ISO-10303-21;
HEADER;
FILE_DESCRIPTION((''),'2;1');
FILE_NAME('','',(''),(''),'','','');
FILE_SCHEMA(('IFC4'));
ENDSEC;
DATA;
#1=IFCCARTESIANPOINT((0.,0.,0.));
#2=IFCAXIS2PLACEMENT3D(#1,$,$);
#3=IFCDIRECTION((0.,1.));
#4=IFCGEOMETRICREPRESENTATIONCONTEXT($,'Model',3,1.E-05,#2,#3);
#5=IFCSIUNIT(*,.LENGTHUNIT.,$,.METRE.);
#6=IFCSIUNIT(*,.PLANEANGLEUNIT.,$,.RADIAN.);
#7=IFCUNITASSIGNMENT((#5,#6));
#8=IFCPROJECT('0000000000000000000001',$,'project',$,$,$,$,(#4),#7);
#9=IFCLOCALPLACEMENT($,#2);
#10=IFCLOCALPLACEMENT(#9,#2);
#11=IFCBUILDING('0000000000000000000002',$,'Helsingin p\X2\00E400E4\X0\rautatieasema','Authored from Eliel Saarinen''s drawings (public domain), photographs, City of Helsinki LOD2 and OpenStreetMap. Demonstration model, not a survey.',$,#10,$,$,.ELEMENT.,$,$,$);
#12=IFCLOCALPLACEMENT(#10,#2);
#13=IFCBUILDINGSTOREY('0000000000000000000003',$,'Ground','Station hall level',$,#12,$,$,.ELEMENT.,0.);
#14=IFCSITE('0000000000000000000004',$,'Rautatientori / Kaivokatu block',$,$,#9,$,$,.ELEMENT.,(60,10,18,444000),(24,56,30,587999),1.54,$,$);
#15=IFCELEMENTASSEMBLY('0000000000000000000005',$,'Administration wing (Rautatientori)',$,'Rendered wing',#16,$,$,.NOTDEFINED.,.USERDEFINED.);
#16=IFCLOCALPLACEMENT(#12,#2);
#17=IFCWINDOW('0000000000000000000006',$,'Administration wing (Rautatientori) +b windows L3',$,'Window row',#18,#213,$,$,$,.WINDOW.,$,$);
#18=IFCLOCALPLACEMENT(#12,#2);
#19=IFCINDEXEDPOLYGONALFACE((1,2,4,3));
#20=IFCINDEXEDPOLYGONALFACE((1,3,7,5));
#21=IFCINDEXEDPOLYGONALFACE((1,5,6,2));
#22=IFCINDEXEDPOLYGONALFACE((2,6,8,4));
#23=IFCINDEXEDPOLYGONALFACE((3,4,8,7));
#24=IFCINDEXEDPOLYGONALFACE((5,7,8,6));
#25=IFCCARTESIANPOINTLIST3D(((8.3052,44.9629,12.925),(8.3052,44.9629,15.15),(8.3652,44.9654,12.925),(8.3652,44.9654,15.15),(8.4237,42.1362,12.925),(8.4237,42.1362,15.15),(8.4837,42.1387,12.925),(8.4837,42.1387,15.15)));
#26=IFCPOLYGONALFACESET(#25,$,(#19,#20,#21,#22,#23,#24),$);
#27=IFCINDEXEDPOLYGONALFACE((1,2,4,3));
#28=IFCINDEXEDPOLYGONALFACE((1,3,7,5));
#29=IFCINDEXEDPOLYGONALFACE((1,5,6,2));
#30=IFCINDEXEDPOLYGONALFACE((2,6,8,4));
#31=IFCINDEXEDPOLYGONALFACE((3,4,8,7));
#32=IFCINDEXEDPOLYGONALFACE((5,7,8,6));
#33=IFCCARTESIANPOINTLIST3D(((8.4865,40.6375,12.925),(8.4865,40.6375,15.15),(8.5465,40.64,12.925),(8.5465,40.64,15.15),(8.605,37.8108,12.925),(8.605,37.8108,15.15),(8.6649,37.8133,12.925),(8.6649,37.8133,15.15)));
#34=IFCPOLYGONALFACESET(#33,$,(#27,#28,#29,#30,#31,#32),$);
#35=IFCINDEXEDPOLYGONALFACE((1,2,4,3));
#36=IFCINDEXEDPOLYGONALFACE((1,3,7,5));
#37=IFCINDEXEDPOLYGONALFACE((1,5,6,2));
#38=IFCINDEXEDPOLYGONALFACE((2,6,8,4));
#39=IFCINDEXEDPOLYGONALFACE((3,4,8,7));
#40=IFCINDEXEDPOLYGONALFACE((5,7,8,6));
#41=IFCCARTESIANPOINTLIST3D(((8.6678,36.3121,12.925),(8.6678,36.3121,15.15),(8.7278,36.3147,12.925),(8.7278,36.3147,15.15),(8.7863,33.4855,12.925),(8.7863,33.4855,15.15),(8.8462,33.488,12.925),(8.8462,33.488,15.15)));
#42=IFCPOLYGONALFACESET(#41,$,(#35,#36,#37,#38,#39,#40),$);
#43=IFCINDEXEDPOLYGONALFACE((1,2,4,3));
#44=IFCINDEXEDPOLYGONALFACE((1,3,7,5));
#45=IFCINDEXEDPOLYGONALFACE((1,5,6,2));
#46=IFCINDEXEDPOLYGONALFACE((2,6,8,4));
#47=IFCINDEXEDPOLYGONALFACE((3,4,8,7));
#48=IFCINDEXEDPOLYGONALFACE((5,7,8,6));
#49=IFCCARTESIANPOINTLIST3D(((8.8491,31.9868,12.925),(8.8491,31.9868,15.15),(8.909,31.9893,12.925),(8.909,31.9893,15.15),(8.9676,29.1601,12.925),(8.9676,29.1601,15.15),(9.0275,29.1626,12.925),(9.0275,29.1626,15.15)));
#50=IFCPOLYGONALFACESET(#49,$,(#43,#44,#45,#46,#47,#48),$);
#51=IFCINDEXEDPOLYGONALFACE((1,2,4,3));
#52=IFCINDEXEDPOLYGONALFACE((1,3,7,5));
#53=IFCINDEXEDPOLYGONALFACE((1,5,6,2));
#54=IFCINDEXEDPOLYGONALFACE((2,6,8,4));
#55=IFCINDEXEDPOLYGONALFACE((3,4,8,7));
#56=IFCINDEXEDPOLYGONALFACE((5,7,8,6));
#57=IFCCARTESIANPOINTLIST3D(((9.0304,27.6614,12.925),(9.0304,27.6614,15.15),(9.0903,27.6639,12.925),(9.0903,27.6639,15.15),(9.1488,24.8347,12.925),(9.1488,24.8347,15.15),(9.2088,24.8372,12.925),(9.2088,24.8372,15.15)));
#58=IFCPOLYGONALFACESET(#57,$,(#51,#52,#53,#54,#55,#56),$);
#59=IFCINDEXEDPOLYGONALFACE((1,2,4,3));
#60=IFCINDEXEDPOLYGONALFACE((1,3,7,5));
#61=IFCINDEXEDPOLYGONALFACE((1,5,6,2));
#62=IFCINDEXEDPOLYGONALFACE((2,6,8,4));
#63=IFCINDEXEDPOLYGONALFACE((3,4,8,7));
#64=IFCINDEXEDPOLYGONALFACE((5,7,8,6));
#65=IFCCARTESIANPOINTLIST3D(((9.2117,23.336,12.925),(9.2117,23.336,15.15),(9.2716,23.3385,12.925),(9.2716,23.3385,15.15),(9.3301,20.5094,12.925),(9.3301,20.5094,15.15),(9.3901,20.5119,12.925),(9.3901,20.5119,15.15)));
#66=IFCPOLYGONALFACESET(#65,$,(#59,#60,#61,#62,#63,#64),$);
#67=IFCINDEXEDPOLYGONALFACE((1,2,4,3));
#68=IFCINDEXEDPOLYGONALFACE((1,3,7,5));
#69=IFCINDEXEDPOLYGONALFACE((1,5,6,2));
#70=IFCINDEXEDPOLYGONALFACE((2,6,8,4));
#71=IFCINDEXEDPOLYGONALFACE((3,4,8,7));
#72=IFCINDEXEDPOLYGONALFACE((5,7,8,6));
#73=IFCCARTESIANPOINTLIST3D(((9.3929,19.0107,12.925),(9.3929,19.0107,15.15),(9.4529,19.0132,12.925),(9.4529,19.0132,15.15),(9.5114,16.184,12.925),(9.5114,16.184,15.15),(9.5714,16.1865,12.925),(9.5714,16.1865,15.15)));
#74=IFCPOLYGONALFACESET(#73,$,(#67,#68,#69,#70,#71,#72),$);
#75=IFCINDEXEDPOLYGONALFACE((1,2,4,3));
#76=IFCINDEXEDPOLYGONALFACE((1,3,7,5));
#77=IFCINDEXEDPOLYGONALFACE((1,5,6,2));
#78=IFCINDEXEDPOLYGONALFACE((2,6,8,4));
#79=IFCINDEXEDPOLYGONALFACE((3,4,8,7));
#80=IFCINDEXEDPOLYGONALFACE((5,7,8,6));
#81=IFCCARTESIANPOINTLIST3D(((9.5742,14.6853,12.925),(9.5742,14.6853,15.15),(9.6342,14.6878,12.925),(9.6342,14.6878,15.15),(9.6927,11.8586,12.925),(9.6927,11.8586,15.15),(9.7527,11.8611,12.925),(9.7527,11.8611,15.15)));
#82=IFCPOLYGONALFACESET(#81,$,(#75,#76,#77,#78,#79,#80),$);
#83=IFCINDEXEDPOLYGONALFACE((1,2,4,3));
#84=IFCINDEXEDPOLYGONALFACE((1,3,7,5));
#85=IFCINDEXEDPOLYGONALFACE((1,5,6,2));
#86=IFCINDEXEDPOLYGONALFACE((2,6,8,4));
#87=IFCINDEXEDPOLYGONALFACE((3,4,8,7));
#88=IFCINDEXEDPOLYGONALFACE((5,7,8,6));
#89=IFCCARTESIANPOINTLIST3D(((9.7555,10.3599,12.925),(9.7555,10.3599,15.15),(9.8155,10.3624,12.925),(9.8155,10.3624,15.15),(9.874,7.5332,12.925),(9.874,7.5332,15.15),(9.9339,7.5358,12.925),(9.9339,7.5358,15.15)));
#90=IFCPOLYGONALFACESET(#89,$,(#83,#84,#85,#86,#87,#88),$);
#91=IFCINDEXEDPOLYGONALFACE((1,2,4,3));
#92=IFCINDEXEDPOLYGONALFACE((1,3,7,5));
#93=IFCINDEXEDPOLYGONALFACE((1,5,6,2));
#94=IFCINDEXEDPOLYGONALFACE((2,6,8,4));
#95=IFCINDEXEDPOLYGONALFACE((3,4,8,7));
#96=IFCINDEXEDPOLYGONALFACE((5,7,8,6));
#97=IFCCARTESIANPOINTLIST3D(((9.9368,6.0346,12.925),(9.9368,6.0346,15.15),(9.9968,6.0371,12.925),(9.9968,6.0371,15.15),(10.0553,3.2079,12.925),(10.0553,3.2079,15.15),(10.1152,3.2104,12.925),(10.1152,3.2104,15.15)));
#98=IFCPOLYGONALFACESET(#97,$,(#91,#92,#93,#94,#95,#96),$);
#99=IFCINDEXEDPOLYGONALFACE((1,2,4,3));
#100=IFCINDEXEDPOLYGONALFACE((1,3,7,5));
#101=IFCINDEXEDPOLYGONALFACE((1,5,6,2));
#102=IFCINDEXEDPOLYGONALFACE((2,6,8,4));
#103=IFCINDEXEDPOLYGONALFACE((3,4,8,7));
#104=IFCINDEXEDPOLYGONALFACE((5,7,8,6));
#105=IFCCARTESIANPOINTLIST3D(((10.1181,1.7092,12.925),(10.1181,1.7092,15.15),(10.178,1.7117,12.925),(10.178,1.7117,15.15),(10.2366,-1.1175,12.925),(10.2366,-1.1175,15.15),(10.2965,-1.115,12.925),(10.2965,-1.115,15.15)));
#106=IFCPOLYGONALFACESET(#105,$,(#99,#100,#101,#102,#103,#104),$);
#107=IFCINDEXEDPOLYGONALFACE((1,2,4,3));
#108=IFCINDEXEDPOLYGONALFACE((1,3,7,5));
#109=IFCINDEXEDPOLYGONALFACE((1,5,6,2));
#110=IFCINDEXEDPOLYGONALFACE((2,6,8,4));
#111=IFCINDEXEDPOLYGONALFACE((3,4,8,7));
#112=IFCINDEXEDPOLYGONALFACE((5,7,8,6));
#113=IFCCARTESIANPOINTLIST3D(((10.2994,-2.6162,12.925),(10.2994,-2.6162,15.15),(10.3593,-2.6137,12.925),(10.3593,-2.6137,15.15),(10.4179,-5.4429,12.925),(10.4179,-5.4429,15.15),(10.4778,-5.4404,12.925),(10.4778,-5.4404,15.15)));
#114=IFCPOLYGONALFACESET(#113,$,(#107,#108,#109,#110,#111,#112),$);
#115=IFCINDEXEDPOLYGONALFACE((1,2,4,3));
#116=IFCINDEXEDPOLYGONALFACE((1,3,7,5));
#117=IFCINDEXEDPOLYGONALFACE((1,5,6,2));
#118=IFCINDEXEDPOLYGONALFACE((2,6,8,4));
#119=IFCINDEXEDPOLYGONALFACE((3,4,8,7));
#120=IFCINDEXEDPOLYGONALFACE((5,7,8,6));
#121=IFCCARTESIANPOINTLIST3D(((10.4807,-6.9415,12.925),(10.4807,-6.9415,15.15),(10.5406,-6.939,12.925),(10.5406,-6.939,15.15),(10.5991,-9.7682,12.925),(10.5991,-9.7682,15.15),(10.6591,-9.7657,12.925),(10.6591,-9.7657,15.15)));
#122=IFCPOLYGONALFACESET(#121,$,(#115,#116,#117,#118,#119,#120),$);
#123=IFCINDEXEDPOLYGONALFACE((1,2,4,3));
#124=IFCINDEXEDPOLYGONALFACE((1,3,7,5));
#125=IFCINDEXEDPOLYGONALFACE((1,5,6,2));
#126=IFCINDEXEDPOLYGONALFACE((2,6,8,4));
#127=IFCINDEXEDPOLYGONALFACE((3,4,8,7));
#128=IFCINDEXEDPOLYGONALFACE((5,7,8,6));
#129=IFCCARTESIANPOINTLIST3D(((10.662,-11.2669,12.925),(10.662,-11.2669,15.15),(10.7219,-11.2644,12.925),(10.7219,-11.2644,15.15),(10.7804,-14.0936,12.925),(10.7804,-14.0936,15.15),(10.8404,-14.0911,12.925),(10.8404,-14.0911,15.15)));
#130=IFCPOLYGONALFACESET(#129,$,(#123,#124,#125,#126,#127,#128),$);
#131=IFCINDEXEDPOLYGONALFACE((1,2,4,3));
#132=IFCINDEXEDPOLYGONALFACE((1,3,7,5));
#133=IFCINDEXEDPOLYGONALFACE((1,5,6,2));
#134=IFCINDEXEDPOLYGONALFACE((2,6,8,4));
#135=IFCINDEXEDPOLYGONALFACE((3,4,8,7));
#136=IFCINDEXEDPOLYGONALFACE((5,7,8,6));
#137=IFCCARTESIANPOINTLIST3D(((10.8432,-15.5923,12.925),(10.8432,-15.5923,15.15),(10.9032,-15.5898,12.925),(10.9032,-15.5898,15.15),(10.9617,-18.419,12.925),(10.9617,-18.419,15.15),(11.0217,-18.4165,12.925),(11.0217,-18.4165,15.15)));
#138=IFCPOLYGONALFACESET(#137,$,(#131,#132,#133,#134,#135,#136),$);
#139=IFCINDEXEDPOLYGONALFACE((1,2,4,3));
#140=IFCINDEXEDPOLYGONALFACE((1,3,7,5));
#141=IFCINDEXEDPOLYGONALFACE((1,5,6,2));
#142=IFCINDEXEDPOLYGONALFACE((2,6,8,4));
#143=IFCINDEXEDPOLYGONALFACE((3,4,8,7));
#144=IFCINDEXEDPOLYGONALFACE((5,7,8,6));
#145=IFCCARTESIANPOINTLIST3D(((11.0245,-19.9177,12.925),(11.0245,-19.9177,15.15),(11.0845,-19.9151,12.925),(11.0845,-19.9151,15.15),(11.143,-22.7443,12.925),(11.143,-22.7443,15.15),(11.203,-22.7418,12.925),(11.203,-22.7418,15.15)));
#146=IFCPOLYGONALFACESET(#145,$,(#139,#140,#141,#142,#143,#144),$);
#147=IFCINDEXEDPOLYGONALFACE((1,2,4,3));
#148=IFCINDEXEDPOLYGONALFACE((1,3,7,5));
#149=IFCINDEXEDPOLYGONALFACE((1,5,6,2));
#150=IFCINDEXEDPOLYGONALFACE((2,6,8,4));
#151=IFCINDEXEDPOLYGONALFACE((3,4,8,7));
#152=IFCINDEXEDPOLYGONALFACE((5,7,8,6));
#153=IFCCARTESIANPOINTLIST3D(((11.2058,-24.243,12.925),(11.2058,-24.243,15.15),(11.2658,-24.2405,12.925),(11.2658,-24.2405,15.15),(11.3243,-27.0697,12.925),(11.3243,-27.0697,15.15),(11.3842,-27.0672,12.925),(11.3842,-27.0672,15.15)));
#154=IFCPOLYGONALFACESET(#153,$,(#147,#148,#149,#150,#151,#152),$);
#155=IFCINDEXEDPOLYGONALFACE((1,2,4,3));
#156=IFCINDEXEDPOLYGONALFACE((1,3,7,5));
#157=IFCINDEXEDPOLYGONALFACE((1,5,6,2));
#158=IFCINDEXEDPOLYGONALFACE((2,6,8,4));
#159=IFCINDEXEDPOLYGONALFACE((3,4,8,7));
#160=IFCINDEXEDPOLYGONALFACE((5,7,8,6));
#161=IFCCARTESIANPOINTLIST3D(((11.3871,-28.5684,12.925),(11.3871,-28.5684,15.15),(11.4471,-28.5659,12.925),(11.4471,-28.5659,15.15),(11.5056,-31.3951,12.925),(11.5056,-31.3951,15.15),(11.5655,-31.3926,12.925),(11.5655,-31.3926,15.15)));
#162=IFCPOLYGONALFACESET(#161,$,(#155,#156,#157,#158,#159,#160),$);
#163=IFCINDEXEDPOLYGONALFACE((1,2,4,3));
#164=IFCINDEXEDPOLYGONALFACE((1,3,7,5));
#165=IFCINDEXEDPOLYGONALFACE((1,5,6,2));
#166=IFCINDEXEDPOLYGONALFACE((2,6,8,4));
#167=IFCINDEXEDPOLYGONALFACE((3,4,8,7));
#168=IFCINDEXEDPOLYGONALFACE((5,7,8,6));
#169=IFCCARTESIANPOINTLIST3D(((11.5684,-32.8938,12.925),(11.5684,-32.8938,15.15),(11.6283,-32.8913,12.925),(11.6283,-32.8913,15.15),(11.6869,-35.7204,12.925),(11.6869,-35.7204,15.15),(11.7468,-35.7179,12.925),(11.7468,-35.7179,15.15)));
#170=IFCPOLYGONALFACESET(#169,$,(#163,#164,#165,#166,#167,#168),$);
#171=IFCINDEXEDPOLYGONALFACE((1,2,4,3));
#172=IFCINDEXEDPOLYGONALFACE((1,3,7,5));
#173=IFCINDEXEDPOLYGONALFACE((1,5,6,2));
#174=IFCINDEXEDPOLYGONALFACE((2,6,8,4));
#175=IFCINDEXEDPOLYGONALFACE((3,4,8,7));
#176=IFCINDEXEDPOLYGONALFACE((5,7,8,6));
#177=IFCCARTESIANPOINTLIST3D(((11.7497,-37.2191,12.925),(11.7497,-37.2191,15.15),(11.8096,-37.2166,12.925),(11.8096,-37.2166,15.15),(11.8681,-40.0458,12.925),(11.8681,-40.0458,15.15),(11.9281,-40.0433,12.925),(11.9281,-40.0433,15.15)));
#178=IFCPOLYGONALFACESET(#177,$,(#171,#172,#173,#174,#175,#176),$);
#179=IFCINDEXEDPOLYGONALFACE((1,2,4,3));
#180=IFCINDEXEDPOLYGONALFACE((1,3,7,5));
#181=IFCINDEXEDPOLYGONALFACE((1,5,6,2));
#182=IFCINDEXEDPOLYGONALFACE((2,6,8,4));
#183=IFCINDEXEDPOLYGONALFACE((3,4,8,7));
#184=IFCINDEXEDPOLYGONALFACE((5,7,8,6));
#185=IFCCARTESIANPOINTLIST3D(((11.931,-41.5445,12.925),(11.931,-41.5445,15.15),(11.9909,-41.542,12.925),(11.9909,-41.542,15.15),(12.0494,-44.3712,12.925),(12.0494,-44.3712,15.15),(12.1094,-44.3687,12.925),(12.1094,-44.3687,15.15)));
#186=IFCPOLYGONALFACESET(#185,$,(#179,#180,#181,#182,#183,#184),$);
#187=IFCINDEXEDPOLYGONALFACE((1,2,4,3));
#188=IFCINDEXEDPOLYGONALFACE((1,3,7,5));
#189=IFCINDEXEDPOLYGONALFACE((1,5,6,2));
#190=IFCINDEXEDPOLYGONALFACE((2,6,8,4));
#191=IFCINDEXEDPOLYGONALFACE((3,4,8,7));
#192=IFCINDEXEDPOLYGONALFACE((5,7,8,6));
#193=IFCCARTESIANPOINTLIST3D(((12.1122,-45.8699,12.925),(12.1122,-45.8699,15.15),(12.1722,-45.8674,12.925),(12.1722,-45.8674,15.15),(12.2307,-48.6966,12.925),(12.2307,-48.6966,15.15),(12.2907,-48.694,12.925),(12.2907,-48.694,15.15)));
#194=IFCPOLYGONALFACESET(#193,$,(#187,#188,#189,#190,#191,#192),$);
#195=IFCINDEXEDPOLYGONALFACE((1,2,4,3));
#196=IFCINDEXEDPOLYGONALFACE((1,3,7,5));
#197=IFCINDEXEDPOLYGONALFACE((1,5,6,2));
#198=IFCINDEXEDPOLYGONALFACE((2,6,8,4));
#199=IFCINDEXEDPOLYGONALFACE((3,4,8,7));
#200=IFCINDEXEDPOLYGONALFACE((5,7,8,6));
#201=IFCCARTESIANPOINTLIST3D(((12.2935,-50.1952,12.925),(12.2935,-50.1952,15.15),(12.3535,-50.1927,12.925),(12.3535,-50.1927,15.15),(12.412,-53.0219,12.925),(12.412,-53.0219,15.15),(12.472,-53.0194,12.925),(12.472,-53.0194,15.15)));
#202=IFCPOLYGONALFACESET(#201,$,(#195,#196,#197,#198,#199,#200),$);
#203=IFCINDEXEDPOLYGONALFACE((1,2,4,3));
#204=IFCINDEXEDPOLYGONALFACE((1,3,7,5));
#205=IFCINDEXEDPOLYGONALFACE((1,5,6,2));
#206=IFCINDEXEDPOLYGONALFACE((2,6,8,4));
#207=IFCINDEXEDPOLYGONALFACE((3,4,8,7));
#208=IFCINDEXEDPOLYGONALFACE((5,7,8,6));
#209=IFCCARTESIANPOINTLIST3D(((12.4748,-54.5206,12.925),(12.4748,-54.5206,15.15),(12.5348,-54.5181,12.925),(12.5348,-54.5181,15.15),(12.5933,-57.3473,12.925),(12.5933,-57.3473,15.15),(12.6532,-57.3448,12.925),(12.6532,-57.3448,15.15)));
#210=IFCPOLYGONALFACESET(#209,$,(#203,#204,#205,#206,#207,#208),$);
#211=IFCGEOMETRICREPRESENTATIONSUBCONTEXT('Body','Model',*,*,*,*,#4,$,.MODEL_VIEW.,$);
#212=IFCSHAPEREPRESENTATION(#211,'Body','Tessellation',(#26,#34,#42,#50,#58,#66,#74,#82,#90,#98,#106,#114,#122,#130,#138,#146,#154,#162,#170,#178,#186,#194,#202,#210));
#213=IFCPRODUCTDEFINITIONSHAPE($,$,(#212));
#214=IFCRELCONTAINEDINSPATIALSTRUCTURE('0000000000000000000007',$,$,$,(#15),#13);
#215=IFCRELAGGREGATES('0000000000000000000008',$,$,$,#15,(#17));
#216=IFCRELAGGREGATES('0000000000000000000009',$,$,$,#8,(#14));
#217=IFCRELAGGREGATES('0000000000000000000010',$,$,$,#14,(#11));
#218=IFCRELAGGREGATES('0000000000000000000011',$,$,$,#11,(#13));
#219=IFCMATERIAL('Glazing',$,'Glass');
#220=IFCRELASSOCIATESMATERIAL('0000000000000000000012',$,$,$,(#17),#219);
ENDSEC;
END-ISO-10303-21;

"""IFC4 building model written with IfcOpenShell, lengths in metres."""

from ifc_helpers import new_model, si_unit, direction, frame, frame_2d, origin, place, context, subcontext, project, spatial, rectangle, extrude, material, element, aggregate, save


model = new_model("IFC4")

# Units and contexts
model_context = context("Model", 3, precision=1e-05, world=origin(), true_north=direction((0.0, 1.0)))
body_context = subcontext(model_context, "Body", "Model", "MODEL_VIEW")
ifc_project = project(units=[si_unit("LENGTHUNIT", "METRE"), si_unit("PLANEANGLEUNIT", "RADIAN")], contexts=[model_context])

# Site, building, storey
site_placement = place(None, origin())
site = spatial("IfcSite", under=ifc_project, at=site_placement, Name="Rautatientori / Kaivokatu block", CompositionType="ELEMENT", RefLatitude=(60, 10, 18, 444000), RefLongitude=(24, 56, 30, 587999), RefElevation=1.54)
building_placement = place(site_placement, origin())
building = spatial("IfcBuilding", under=site, at=building_placement, Name="Helsingin päärautatieasema", Description="Authored from Eliel Saarinen's drawings (public domain), photographs, City of Helsinki LOD2 and OpenStreetMap. Demonstration model, not a survey.", CompositionType="ELEMENT")
storey_placement = place(building_placement, origin())
storey = spatial("IfcBuildingStorey", under=building, at=storey_placement, Name="Ground", Description="Station hall level", CompositionType="ELEMENT", Elevation=0.0)

# Element assembly, window
assembly_placement = place(building_placement, origin())
assembly = element("IfcElementAssembly", 1, at=assembly_placement, inside=storey, Name="Administration wing (Rautatientori)", ObjectType="Rendered wing", AssemblyPlace="NOTDEFINED", PredefinedType="USERDEFINED")
ifc_material_1 = material(Name="Glazing", Category="Glass")
window_1_placement = place(building_placement, origin())
window_1 = element("IfcWindow", 2, at=window_1_placement, material=ifc_material_1, Name="Administration wing (Rautatientori) +b windows L3", ObjectType="Window row", PredefinedType="WINDOW", context=body_context, shape_type="SweptSolid", body=[
    extrude(rectangle(XDim=2.8292, YDim=0.06, at=frame_2d((0.0, 0.0), x_axis=(0.041876, -0.999123))), frame((8.3944, 43.5508, 12.925)), (0.0, 0.0, 1.0), 2.225),
    extrude(rectangle(XDim=2.8292, YDim=0.06, at=frame_2d((0.0, 0.0), x_axis=(0.041876, -0.999123))), frame((8.5757, 39.2254, 12.925)), (0.0, 0.0, 1.0), 2.225),
    extrude(rectangle(XDim=2.8292, YDim=0.06, at=frame_2d((0.0, 0.0), x_axis=(0.041876, -0.999123))), frame((8.757, 34.9001, 12.925)), (0.0, 0.0, 1.0), 2.225),
    extrude(rectangle(XDim=2.8292, YDim=0.06, at=frame_2d((0.0, 0.0), x_axis=(0.041876, -0.999123))), frame((8.9383, 30.5747, 12.925)), (0.0, 0.0, 1.0), 2.225),
    extrude(rectangle(XDim=2.8292, YDim=0.06, at=frame_2d((0.0, 0.0), x_axis=(0.041876, -0.999123))), frame((9.1196, 26.2493, 12.925)), (0.0, 0.0, 1.0), 2.225),
    extrude(rectangle(XDim=2.8292, YDim=0.06, at=frame_2d((0.0, 0.0), x_axis=(0.041876, -0.999123))), frame((9.3009, 21.9239, 12.925)), (0.0, 0.0, 1.0), 2.225),
    extrude(rectangle(XDim=2.8292, YDim=0.06, at=frame_2d((0.0, 0.0), x_axis=(0.041876, -0.999123))), frame((9.4822, 17.5986, 12.925)), (0.0, 0.0, 1.0), 2.225),
    extrude(rectangle(XDim=2.8292, YDim=0.06, at=frame_2d((0.0, 0.0), x_axis=(0.041876, -0.999123))), frame((9.6634, 13.2732, 12.925)), (0.0, 0.0, 1.0), 2.225),
    extrude(rectangle(XDim=2.8292, YDim=0.06, at=frame_2d((0.0, 0.0), x_axis=(0.041876, -0.999123))), frame((9.8447, 8.9478, 12.925)), (0.0, 0.0, 1.0), 2.225),
    extrude(rectangle(XDim=2.8292, YDim=0.06, at=frame_2d((0.0, 0.0), x_axis=(0.041876, -0.999123))), frame((10.026, 4.6225, 12.925)), (0.0, 0.0, 1.0), 2.225),
    extrude(rectangle(XDim=2.8292, YDim=0.06, at=frame_2d((0.0, 0.0), x_axis=(0.041876, -0.999123))), frame((10.2073, 0.2971, 12.925)), (0.0, 0.0, 1.0), 2.225),
    extrude(rectangle(XDim=2.8292, YDim=0.06, at=frame_2d((0.0, 0.0), x_axis=(0.041876, -0.999123))), frame((10.3886, -4.0283, 12.925)), (0.0, 0.0, 1.0), 2.225),
    extrude(rectangle(XDim=2.8292, YDim=0.06, at=frame_2d((0.0, 0.0), x_axis=(0.041876, -0.999123))), frame((10.5699, -8.3536, 12.925)), (0.0, 0.0, 1.0), 2.225),
    extrude(rectangle(XDim=2.8292, YDim=0.06, at=frame_2d((0.0, 0.0), x_axis=(0.041876, -0.999123))), frame((10.7512, -12.679, 12.925)), (0.0, 0.0, 1.0), 2.225),
    extrude(rectangle(XDim=2.8292, YDim=0.06, at=frame_2d((0.0, 0.0), x_axis=(0.041876, -0.999123))), frame((10.9325, -17.0044, 12.925)), (0.0, 0.0, 1.0), 2.225),
    extrude(rectangle(XDim=2.8292, YDim=0.06, at=frame_2d((0.0, 0.0), x_axis=(0.041876, -0.999123))), frame((11.1137, -21.3297, 12.925)), (0.0, 0.0, 1.0), 2.225),
    extrude(rectangle(XDim=2.8292, YDim=0.06, at=frame_2d((0.0, 0.0), x_axis=(0.041876, -0.999123))), frame((11.295, -25.6551, 12.925)), (0.0, 0.0, 1.0), 2.225),
    extrude(rectangle(XDim=2.8292, YDim=0.06, at=frame_2d((0.0, 0.0), x_axis=(0.041876, -0.999123))), frame((11.4763, -29.9805, 12.925)), (0.0, 0.0, 1.0), 2.225),
    extrude(rectangle(XDim=2.8292, YDim=0.06, at=frame_2d((0.0, 0.0), x_axis=(0.041876, -0.999123))), frame((11.6576, -34.3059, 12.925)), (0.0, 0.0, 1.0), 2.225),
    extrude(rectangle(XDim=2.8292, YDim=0.06, at=frame_2d((0.0, 0.0), x_axis=(0.041876, -0.999123))), frame((11.8389, -38.6312, 12.925)), (0.0, 0.0, 1.0), 2.225),
    extrude(rectangle(XDim=2.8292, YDim=0.06, at=frame_2d((0.0, 0.0), x_axis=(0.041876, -0.999123))), frame((12.0202, -42.9566, 12.925)), (0.0, 0.0, 1.0), 2.225),
    extrude(rectangle(XDim=2.8292, YDim=0.06, at=frame_2d((0.0, 0.0), x_axis=(0.041876, -0.999123))), frame((12.2015, -47.282, 12.925)), (0.0, 0.0, 1.0), 2.225),
    extrude(rectangle(XDim=2.8292, YDim=0.06, at=frame_2d((0.0, 0.0), x_axis=(0.041876, -0.999123))), frame((12.3827, -51.6073, 12.925)), (0.0, 0.0, 1.0), 2.225),
    extrude(rectangle(XDim=2.8292, YDim=0.06, at=frame_2d((0.0, 0.0), x_axis=(0.041876, -0.999123))), frame((12.564, -55.9327, 12.925)), (0.0, 0.0, 1.0), 2.225),
])
aggregate(assembly, [window_1])

save(model, "model.ifc")
